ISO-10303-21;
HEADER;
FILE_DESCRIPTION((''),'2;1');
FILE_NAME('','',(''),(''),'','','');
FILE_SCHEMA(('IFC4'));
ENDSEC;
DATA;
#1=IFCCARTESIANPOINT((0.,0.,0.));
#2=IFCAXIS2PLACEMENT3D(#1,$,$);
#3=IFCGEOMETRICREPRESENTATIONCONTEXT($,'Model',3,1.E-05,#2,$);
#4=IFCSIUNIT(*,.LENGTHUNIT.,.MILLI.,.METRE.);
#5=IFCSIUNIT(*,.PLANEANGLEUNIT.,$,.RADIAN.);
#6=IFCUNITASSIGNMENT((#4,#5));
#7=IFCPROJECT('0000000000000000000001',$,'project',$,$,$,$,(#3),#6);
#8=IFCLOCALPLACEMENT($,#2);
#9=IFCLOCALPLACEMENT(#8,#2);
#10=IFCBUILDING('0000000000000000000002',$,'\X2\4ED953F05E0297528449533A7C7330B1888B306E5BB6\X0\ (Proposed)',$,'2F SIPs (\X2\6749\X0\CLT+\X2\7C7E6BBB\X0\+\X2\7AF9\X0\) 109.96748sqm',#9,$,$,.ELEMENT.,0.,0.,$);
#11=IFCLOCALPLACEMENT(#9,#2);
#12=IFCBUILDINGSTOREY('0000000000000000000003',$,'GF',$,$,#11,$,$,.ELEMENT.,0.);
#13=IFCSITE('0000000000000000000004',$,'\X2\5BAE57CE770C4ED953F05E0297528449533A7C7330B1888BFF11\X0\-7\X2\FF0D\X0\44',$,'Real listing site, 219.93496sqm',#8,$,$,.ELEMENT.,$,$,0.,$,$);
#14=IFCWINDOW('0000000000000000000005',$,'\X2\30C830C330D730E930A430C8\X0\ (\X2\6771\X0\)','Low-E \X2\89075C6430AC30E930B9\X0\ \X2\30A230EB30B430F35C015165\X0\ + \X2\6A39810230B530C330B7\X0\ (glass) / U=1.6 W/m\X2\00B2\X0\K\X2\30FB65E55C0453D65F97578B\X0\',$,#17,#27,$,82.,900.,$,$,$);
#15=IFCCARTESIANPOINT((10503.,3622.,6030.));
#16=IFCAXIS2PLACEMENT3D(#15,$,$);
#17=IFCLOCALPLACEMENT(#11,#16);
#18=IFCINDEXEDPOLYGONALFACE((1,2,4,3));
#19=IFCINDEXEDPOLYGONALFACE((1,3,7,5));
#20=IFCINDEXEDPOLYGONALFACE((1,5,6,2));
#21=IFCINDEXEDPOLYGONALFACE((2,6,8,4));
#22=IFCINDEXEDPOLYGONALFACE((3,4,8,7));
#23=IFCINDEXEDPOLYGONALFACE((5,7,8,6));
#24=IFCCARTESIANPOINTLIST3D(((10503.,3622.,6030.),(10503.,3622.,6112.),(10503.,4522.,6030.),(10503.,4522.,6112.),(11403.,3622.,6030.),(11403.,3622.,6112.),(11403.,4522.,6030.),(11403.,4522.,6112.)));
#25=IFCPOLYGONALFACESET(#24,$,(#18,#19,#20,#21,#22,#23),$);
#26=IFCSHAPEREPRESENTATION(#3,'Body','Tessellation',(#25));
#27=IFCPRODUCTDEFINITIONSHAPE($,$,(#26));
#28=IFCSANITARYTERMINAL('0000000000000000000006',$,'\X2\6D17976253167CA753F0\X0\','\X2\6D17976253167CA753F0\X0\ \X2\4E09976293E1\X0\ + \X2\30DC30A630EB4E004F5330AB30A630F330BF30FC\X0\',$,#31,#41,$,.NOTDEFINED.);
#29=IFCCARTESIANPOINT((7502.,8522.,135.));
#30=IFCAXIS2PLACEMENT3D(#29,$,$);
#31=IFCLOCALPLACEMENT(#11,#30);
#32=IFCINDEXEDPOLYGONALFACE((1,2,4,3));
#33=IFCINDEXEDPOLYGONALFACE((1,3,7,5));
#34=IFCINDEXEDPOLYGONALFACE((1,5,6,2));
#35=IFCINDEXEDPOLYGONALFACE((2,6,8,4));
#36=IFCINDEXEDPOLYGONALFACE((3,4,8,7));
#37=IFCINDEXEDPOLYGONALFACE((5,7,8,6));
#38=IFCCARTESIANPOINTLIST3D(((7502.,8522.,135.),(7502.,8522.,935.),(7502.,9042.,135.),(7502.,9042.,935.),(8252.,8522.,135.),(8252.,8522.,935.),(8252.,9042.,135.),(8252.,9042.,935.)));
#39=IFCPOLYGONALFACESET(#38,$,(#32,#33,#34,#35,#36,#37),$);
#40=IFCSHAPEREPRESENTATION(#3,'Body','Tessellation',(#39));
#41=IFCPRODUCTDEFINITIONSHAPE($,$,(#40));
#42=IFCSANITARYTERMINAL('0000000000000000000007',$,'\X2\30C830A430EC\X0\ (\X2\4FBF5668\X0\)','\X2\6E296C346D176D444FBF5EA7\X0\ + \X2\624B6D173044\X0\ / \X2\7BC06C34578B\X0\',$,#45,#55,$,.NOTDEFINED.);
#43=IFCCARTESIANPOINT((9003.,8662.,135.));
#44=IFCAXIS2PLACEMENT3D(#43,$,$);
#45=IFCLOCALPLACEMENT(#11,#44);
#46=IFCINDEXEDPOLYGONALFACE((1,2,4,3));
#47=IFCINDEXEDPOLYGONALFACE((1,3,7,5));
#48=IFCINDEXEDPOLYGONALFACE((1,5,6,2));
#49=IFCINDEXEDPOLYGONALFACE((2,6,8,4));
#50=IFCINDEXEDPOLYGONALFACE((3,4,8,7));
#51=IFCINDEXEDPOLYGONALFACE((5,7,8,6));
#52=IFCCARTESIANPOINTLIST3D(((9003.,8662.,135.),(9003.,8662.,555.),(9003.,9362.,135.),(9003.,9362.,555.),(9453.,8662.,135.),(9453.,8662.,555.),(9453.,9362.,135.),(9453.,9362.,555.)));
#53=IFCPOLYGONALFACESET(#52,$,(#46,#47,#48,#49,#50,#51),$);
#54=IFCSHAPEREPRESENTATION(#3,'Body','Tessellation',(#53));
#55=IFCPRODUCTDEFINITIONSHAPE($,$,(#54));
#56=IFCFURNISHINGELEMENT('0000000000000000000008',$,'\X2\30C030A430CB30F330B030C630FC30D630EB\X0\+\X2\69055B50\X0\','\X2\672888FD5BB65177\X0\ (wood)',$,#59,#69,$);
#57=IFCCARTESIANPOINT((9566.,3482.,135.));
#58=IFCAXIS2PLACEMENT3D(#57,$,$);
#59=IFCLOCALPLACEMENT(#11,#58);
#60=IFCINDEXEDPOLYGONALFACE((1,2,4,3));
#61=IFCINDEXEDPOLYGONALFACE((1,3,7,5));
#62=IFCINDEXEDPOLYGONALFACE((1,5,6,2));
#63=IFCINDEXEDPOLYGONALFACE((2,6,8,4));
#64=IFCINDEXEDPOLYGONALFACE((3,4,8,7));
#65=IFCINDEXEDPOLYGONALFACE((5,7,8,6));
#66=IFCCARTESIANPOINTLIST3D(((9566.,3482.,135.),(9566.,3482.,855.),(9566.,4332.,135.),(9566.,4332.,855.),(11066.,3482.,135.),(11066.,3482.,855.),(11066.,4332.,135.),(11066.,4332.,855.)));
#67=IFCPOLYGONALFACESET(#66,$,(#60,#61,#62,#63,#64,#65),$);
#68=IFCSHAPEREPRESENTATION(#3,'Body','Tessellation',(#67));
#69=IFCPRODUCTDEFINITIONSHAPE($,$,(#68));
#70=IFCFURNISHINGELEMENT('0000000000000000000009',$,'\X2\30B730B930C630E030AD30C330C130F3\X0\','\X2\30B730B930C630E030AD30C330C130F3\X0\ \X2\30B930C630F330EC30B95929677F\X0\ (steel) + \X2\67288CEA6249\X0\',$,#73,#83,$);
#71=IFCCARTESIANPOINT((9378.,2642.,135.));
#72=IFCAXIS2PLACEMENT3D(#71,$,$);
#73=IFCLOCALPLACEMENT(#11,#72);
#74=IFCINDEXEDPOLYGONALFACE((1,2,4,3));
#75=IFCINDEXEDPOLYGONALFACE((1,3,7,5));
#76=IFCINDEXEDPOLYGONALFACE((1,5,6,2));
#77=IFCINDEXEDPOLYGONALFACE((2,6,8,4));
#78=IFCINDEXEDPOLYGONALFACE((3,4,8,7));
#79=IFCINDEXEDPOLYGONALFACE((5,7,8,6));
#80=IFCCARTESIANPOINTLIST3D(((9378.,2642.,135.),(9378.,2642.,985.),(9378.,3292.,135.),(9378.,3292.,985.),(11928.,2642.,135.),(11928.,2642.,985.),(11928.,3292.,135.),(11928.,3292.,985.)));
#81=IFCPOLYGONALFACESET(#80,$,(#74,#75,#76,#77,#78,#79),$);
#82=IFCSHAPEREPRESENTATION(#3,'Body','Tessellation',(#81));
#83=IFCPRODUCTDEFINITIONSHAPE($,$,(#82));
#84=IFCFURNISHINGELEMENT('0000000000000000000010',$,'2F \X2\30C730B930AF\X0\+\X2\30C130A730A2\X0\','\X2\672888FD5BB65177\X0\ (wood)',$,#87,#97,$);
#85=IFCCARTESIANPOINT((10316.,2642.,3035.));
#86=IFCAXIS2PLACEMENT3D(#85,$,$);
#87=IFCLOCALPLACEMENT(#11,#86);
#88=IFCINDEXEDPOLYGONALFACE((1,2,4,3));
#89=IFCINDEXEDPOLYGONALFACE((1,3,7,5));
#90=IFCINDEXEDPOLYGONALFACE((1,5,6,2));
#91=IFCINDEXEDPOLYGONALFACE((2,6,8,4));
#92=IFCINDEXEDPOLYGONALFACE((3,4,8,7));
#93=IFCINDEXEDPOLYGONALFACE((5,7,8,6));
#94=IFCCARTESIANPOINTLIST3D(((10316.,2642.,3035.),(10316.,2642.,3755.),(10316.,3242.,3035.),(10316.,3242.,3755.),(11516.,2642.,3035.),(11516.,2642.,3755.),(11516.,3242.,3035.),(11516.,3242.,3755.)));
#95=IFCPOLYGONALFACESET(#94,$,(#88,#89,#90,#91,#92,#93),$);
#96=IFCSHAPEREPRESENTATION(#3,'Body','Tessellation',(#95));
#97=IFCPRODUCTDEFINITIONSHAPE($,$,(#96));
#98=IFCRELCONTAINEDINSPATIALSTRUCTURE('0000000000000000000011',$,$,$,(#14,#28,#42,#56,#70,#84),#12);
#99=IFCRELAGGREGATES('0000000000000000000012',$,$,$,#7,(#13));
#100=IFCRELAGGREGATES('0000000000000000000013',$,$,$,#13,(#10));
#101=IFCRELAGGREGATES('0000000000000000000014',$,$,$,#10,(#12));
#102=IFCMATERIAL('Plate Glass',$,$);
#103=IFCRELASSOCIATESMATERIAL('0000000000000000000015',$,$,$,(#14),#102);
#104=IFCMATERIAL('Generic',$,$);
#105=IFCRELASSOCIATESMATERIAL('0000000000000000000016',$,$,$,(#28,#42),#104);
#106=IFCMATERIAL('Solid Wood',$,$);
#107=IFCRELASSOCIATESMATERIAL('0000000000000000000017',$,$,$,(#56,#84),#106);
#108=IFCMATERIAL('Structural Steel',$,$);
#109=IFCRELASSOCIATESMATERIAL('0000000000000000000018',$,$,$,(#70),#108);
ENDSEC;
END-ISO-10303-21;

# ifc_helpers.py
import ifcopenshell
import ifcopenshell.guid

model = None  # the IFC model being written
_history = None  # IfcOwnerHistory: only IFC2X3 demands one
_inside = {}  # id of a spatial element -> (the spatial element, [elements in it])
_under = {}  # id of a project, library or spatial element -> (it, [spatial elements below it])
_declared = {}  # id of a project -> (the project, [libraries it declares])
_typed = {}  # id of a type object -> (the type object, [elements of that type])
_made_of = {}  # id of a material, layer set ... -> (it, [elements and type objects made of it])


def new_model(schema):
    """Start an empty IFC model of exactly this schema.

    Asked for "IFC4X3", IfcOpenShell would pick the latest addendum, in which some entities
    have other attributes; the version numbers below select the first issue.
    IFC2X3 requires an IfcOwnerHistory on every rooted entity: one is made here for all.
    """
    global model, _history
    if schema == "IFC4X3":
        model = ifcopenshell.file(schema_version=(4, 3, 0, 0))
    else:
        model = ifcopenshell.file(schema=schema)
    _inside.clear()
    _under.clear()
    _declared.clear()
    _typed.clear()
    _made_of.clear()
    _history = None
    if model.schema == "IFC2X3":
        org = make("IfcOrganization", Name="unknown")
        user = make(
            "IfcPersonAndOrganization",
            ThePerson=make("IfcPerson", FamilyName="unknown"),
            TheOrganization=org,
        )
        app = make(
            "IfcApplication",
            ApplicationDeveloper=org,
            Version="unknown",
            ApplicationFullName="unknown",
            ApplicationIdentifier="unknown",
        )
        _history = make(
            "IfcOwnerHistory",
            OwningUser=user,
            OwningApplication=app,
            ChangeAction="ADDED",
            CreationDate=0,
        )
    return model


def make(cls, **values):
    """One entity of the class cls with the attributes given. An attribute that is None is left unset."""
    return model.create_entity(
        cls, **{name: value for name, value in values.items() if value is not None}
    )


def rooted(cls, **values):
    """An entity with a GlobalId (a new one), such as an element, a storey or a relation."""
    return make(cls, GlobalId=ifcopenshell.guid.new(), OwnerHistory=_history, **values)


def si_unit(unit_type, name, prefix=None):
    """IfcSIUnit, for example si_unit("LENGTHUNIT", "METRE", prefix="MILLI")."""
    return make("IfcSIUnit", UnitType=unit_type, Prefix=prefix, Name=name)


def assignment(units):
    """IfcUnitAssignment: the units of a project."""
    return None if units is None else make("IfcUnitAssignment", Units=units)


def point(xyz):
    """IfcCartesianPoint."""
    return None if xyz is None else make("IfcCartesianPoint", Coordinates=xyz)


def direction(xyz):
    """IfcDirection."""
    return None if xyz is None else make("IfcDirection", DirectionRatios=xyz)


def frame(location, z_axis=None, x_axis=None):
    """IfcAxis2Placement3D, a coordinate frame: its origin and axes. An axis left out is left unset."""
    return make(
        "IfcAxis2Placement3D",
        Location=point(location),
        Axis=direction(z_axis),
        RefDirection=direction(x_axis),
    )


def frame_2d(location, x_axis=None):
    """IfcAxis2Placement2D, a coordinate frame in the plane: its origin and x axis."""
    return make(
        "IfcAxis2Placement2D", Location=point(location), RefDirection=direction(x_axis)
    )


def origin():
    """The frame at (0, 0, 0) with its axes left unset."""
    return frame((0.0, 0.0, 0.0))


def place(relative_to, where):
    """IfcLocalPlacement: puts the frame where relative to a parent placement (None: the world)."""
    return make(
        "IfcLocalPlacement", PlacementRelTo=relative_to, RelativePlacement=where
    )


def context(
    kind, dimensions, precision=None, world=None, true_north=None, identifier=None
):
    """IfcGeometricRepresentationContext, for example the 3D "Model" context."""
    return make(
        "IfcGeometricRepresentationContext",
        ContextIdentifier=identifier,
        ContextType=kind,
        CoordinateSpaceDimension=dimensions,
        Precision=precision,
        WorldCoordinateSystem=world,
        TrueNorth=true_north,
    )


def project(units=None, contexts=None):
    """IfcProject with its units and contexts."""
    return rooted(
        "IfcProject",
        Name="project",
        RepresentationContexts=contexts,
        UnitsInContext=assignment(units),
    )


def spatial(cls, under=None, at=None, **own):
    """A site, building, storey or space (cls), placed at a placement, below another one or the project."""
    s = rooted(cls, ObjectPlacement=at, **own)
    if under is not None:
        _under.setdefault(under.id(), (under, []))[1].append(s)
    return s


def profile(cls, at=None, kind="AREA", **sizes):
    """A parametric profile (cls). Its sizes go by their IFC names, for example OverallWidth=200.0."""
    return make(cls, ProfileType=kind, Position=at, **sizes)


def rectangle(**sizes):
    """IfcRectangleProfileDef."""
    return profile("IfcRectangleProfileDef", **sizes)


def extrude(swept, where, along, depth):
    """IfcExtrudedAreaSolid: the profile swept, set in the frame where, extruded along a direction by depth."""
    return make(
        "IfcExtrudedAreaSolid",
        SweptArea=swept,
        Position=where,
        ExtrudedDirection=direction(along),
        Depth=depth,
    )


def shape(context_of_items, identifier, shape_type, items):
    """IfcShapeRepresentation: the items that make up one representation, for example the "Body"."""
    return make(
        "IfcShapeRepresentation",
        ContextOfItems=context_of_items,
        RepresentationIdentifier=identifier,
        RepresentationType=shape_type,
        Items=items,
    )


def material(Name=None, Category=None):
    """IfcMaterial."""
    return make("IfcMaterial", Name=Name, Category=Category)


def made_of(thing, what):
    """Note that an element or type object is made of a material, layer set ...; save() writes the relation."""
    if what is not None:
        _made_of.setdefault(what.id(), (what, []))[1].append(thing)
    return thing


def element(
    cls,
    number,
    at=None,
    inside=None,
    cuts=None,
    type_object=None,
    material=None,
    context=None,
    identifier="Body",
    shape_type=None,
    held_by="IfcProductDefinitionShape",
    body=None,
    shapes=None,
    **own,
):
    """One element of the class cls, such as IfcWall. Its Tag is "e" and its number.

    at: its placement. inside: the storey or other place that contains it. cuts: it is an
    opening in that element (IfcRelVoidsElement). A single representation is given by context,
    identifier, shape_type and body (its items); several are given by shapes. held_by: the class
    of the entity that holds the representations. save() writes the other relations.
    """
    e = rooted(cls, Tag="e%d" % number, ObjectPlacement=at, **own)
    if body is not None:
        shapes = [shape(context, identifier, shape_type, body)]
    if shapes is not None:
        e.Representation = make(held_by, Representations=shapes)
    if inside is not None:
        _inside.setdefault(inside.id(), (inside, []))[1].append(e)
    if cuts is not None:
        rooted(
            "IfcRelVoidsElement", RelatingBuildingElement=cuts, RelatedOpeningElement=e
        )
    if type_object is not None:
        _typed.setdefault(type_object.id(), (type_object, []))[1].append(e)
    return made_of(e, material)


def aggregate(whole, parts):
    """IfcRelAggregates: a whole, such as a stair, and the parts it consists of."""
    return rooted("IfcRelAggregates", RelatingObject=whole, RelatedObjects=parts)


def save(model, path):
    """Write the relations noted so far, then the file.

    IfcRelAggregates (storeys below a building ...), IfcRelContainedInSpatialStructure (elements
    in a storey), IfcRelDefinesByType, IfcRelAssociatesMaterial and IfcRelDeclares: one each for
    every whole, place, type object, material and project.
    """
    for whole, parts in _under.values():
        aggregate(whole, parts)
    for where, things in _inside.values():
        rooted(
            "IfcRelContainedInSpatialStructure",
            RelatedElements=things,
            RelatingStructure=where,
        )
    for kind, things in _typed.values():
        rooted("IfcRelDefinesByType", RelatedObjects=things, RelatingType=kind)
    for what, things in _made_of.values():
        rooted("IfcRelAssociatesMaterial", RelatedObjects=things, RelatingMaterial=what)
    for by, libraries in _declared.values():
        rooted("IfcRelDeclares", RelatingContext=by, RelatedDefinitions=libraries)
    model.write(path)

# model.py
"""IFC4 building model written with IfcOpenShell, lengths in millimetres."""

from ifc_helpers import new_model, si_unit, frame, frame_2d, origin, place, context, project, spatial, rectangle, extrude, material, element, save


model = new_model("IFC4")

# Units and contexts
model_context = context("Model", 3, precision=1e-05, world=origin())
ifc_project = project(units=[si_unit("LENGTHUNIT", "METRE", prefix="MILLI"), si_unit("PLANEANGLEUNIT", "RADIAN")], contexts=[model_context])

# Site, building, storey
site_placement = place(None, origin())
site = spatial("IfcSite", under=ifc_project, at=site_placement, Name="宮城県仙台市青葉区米ケ袋１-7－44", ObjectType="Real listing site, 219.93496sqm", CompositionType="ELEMENT", RefElevation=0.0)
building_placement = place(site_placement, origin())
building = spatial("IfcBuilding", under=site, at=building_placement, Name="仙台市青葉区米ケ袋の家 (Proposed)", ObjectType="2F SIPs (杉CLT+籾殻+竹) 109.96748sqm", CompositionType="ELEMENT", ElevationOfRefHeight=0.0, ElevationOfTerrain=0.0)
storey_placement = place(building_placement, origin())
storey = spatial("IfcBuildingStorey", under=building, at=storey_placement, Name="GF", CompositionType="ELEMENT", Elevation=0.0)

# Shared definitions
ifc_material_1 = material(Name="Solid Wood")

# Shared definitions
ifc_material_2 = material(Name="Plate Glass")

# Window
window_1_placement = place(storey_placement, frame((10503.0, 3622.0, 6030.0)))
element("IfcWindow", 1, at=window_1_placement, inside=storey, material=ifc_material_2, Name="トップライト (東)", Description="Low-E 複層ガラス アルゴン封入 + 樹脂サッシ (glass) / U=1.6 W/m²K・日射取得型", OverallHeight=82.0, OverallWidth=900.0, context=model_context, shape_type="SweptSolid", body=[
    extrude(rectangle(XDim=900.0, YDim=900.0, at=frame_2d((450.0, 450.0))), frame((10503.0, 3622.0, 6030.0)), (0.0, 0.0, 1.0), 82.0),
])

# Sanitary terminals
ifc_material_3 = material(Name="Generic")
sanitary_terminal_1_placement = place(storey_placement, frame((7502.0, 8522.0, 135.0)))
element("IfcSanitaryTerminal", 2, at=sanitary_terminal_1_placement, inside=storey, material=ifc_material_3, Name="洗面化粧台", Description="洗面化粧台 三面鏡 + ボウル一体カウンター", PredefinedType="NOTDEFINED", context=model_context, shape_type="SweptSolid", body=[
    extrude(rectangle(XDim=750.0, YDim=520.0, at=frame_2d((375.0, 260.0))), frame((7502.0, 8522.0, 135.0)), (0.0, 0.0, 1.0), 800.0),
])
sanitary_terminal_2_placement = place(storey_placement, frame((9003.0, 8662.0, 135.0)))
element("IfcSanitaryTerminal", 3, at=sanitary_terminal_2_placement, inside=storey, material=ifc_material_3, Name="トイレ (便器)", Description="温水洗浄便座 + 手洗い / 節水型", PredefinedType="NOTDEFINED", context=model_context, shape_type="SweptSolid", body=[
    extrude(rectangle(XDim=450.0, YDim=700.0, at=frame_2d((225.0, 350.0))), frame((9003.0, 8662.0, 135.0)), (0.0, 0.0, 1.0), 420.0),
])

# Furnishing elements
furnishing_1_placement = place(storey_placement, frame((9566.0, 3482.0, 135.0)))
element("IfcFurnishingElement", 4, at=furnishing_1_placement, inside=storey, material=ifc_material_1, Name="ダイニングテーブル+椅子", Description="木製家具 (wood)", context=model_context, shape_type="SweptSolid", body=[
    extrude(rectangle(XDim=1500.0, YDim=850.0, at=frame_2d((750.0, 425.0))), frame((9566.0, 3482.0, 135.0)), (0.0, 0.0, 1.0), 720.0),
])
ifc_material_4 = material(Name="Structural Steel")
furnishing_2_placement = place(storey_placement, frame((9378.0, 2642.0, 135.0)))
element("IfcFurnishingElement", 5, at=furnishing_2_placement, inside=storey, material=ifc_material_4, Name="システムキッチン", Description="システムキッチン ステンレス天板 (steel) + 木質扉", context=model_context, shape_type="SweptSolid", body=[
    extrude(rectangle(XDim=2550.0, YDim=650.0, at=frame_2d((1275.0, 325.0))), frame((9378.0, 2642.0, 135.0)), (0.0, 0.0, 1.0), 850.0),
])
furnishing_3_placement = place(storey_placement, frame((10316.0, 2642.0, 3035.0)))
element("IfcFurnishingElement", 6, at=furnishing_3_placement, inside=storey, material=ifc_material_1, Name="2F デスク+チェア", Description="木製家具 (wood)", context=model_context, shape_type="SweptSolid", body=[
    extrude(rectangle(XDim=1200.0, YDim=600.0, at=frame_2d((600.0, 300.0))), frame((10316.0, 2642.0, 3035.0)), (0.0, 0.0, 1.0), 720.0),
])

save(model, "model.ifc")
